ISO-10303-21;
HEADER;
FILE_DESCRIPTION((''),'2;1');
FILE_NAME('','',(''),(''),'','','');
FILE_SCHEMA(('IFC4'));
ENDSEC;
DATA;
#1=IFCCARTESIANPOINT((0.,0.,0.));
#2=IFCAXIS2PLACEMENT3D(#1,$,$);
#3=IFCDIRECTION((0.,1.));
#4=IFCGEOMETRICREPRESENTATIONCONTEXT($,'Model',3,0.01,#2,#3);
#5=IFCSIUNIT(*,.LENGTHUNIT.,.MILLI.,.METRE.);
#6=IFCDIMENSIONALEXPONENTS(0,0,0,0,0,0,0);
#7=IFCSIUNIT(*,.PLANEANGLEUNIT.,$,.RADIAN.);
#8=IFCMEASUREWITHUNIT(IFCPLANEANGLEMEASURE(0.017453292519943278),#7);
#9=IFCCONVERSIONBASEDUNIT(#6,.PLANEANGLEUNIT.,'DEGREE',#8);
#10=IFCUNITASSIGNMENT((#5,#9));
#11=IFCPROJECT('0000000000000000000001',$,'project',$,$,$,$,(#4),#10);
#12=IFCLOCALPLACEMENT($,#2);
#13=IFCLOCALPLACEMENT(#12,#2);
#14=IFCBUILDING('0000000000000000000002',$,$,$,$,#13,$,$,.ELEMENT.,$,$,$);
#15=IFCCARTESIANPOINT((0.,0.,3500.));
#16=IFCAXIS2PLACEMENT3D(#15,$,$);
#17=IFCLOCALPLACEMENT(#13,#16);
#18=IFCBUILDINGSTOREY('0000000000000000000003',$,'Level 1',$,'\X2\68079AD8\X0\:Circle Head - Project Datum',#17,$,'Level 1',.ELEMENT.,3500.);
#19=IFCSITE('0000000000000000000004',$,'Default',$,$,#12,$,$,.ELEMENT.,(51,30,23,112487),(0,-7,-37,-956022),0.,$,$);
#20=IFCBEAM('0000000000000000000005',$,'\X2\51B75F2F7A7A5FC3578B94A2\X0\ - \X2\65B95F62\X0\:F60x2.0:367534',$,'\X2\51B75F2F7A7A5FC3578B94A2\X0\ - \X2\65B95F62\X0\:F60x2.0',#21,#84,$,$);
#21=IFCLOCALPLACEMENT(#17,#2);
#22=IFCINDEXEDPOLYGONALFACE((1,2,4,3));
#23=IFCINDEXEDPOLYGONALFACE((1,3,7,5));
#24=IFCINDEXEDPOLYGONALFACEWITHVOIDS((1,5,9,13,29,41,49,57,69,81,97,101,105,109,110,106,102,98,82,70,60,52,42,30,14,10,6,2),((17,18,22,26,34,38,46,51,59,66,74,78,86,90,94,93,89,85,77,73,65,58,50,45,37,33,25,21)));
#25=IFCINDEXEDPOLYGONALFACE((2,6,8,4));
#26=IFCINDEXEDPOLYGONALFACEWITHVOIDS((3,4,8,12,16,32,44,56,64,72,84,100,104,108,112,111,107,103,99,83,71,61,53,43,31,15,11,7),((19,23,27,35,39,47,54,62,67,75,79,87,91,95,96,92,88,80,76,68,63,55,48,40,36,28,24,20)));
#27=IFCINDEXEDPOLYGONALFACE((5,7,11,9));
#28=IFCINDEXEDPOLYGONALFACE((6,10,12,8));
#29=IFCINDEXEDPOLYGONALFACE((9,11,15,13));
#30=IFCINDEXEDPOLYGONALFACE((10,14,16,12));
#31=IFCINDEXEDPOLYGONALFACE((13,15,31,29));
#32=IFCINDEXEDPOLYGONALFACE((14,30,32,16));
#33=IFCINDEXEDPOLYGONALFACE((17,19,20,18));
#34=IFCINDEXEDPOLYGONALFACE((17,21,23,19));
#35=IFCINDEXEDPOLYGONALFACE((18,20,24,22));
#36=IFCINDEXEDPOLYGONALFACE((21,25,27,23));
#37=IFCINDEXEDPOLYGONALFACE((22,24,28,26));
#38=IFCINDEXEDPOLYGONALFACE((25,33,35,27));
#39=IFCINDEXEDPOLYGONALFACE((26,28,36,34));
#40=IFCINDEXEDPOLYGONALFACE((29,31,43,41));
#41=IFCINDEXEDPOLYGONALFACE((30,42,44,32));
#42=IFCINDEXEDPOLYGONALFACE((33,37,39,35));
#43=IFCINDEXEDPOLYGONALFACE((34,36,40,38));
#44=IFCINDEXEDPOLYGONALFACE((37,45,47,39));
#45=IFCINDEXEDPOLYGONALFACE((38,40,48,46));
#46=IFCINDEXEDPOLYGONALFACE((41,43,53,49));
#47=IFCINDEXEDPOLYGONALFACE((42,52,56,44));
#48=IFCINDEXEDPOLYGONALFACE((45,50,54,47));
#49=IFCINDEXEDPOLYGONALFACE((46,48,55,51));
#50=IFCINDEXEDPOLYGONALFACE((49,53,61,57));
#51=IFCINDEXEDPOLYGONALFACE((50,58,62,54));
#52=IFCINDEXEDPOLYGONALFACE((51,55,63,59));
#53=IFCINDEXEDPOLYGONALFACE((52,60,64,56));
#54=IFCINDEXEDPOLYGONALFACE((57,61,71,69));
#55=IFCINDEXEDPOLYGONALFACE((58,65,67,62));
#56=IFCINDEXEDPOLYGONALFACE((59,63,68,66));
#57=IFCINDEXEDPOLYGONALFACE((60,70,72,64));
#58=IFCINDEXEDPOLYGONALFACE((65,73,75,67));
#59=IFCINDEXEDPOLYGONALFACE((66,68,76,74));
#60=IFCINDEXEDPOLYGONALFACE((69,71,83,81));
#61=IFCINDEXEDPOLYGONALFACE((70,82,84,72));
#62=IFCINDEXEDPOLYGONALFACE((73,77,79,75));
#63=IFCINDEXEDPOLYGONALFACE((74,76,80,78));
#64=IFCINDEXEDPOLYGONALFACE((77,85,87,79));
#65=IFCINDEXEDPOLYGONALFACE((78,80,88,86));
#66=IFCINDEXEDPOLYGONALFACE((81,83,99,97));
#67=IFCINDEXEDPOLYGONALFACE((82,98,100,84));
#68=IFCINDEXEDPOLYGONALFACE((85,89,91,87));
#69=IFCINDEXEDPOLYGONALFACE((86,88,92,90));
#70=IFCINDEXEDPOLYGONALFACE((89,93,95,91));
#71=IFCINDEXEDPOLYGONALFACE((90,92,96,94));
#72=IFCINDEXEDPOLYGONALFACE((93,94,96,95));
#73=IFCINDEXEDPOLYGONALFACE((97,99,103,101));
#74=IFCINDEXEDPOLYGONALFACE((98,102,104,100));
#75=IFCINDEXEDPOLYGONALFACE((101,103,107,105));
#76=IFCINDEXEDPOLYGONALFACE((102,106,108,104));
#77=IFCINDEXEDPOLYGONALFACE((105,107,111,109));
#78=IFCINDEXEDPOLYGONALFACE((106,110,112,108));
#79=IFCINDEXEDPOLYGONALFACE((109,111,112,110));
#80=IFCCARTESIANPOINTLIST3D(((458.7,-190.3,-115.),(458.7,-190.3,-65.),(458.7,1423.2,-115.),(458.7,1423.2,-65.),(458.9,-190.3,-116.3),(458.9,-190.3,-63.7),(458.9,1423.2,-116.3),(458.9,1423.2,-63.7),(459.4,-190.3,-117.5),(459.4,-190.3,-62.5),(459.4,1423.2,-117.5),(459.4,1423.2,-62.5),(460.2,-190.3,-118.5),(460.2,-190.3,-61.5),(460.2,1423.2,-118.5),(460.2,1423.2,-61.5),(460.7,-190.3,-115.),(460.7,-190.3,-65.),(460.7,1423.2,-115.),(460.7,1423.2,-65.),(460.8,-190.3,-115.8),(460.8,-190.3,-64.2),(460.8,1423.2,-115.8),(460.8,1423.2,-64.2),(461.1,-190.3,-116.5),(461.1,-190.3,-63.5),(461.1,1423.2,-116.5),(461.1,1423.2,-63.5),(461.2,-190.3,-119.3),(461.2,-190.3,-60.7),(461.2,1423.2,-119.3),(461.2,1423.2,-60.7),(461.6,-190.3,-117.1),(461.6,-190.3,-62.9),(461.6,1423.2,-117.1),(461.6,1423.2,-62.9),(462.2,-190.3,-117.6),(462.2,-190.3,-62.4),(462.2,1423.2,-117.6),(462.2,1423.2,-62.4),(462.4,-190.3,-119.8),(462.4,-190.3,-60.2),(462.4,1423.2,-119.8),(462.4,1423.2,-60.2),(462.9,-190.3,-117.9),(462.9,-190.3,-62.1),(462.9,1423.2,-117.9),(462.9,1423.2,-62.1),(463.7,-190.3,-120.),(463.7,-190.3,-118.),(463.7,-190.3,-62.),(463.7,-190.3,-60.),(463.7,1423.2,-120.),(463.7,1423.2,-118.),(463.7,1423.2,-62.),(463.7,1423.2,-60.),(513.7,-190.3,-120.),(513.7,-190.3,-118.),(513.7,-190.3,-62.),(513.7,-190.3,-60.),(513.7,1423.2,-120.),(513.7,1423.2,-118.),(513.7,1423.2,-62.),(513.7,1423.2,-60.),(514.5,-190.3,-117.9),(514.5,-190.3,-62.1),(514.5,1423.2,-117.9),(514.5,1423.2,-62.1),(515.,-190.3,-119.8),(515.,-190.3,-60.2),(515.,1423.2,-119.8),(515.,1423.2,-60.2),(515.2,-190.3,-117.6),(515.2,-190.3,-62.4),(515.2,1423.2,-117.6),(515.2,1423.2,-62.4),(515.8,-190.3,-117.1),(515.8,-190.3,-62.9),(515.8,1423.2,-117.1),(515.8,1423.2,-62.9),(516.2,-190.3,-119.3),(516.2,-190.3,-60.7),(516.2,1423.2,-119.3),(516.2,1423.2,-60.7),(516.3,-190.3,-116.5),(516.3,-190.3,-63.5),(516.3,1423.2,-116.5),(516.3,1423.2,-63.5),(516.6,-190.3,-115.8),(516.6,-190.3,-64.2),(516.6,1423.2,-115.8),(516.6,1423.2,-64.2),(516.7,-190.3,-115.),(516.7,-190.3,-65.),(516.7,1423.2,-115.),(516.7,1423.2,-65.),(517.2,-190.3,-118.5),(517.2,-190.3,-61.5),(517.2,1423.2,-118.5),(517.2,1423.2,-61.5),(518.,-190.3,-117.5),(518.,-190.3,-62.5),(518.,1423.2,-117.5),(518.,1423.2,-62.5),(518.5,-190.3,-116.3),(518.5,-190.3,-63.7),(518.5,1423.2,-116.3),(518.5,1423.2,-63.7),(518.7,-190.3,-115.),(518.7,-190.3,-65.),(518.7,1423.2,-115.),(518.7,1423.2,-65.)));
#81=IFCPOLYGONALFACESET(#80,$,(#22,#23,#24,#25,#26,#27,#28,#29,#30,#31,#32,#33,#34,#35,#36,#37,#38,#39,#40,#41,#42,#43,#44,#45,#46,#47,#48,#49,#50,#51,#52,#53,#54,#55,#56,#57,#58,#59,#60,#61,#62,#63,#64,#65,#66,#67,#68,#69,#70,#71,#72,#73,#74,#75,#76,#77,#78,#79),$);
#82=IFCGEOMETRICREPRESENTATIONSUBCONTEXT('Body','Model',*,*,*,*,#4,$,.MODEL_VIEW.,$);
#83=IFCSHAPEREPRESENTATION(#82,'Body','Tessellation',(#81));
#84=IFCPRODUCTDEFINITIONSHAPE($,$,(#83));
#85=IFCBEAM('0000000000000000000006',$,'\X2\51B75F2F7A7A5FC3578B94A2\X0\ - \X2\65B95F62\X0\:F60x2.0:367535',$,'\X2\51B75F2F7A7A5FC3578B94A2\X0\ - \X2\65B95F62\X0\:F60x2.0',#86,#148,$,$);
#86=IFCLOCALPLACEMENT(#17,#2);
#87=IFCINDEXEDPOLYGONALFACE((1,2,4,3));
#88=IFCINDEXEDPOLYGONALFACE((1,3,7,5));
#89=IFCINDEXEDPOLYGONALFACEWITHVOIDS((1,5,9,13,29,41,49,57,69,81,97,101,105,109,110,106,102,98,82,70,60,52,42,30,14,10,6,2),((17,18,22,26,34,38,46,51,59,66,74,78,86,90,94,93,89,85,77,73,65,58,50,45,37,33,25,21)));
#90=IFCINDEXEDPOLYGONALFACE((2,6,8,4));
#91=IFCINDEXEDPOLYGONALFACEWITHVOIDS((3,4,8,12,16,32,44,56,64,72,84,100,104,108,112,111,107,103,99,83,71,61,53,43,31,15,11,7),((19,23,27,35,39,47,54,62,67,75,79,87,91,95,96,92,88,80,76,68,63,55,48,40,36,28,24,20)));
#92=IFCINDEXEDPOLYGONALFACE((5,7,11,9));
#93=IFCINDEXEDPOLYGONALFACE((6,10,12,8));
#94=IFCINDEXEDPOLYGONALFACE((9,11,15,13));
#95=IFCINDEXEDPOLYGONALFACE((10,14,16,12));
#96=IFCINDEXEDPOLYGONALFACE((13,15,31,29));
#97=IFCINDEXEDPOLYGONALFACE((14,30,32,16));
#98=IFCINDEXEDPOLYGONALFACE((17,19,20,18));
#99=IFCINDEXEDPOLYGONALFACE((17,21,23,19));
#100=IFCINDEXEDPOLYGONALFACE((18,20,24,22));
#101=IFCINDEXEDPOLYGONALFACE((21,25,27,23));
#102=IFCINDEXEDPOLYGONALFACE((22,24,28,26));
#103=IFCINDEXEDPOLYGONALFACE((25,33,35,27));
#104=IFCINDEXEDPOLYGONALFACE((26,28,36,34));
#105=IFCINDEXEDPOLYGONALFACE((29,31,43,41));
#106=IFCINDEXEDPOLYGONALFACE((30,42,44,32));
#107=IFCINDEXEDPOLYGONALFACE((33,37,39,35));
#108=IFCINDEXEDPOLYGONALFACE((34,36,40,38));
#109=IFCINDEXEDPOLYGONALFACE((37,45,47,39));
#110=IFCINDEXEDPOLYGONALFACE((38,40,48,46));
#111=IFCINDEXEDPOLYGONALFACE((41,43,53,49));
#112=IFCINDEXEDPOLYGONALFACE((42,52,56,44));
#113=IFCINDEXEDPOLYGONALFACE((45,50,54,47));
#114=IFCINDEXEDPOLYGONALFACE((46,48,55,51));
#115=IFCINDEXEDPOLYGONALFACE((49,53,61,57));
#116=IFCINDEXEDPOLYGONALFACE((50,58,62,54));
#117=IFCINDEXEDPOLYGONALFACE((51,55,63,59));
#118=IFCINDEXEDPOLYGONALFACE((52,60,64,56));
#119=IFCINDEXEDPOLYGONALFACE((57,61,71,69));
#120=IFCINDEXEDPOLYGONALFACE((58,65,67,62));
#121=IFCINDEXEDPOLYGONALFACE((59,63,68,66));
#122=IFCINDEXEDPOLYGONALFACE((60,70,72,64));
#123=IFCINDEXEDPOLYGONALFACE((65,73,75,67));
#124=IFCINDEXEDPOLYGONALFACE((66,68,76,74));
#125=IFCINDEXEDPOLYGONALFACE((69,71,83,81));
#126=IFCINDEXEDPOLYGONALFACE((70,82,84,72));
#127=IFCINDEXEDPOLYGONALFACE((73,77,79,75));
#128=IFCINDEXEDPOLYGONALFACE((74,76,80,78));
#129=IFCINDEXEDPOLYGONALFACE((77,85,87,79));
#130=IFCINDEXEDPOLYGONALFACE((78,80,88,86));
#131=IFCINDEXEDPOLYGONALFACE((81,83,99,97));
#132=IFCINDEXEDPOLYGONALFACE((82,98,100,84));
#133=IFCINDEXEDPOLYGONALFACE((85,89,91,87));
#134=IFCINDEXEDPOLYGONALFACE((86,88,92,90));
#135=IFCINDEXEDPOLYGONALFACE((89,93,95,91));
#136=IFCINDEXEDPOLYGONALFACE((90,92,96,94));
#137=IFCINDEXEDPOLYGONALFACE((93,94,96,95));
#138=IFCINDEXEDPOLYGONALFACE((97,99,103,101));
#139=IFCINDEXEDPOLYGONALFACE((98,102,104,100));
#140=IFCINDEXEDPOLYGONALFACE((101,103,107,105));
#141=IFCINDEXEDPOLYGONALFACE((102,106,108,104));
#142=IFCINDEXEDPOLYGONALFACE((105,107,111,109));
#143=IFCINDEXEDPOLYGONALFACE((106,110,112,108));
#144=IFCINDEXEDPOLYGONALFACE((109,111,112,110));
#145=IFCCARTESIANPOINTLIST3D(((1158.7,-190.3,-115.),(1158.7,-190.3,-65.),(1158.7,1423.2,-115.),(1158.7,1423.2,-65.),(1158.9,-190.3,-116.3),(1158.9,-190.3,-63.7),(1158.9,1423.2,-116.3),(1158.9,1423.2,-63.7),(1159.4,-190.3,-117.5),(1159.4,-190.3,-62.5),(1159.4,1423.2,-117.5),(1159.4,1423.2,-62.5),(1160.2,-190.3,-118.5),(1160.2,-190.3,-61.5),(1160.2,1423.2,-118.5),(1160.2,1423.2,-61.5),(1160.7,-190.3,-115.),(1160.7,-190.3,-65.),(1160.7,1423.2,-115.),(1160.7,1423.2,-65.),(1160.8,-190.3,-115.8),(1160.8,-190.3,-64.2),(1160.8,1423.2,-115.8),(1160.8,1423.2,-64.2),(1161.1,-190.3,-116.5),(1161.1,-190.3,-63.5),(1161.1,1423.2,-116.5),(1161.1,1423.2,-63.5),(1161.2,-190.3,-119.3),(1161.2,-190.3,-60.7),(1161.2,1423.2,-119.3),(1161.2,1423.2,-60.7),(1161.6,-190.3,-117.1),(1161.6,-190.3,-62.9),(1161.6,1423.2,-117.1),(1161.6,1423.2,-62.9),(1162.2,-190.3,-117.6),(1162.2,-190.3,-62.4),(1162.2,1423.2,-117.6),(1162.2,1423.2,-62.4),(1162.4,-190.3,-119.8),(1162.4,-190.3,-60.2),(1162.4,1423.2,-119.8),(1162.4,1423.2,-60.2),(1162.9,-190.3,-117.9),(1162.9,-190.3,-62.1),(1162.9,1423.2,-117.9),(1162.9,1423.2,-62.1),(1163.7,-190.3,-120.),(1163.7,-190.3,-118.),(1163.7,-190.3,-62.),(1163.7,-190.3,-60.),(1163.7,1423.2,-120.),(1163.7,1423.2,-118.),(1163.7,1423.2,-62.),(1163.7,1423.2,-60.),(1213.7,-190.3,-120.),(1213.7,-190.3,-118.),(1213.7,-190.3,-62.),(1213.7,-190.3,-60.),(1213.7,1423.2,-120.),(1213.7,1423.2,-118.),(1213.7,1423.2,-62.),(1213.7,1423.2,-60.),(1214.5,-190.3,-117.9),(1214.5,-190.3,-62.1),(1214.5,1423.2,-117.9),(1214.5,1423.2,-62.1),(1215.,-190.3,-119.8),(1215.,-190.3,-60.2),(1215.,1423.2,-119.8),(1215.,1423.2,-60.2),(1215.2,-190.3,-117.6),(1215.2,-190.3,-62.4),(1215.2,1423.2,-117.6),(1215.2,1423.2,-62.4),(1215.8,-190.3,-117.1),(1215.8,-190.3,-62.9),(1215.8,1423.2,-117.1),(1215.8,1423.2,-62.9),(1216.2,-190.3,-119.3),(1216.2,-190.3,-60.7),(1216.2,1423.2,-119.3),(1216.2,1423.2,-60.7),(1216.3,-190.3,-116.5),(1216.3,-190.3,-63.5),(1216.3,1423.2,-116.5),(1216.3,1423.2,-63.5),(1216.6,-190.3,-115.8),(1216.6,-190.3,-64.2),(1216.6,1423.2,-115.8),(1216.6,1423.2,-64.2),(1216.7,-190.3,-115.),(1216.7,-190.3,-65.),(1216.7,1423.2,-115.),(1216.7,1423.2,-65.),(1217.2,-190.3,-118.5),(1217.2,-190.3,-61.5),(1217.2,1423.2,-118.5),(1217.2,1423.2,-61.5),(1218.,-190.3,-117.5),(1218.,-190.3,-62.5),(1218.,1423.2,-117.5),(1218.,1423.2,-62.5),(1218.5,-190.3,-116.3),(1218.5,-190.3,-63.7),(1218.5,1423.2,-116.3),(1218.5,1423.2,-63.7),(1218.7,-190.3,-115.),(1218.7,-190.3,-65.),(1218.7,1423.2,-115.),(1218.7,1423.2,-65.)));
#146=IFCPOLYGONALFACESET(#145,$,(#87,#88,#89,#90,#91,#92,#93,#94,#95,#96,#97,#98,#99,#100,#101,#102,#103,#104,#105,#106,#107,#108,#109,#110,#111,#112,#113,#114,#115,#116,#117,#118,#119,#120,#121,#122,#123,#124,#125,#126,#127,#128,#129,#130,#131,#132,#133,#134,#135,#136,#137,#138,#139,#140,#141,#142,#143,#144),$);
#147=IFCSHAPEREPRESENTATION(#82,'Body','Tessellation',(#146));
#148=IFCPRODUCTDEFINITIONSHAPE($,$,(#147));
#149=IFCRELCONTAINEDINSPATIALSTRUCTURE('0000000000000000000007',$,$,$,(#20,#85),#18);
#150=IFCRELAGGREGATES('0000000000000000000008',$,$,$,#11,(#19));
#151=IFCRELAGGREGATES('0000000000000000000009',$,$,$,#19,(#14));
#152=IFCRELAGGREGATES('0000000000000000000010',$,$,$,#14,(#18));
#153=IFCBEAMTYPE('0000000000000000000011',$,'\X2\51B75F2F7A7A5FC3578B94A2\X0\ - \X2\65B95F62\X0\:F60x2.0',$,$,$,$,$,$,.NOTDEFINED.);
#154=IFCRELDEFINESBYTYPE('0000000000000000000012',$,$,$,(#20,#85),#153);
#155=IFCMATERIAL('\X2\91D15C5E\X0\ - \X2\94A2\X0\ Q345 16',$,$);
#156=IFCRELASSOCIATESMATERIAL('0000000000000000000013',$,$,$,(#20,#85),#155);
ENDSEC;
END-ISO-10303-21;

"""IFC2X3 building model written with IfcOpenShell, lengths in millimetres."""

from ifc_helpers import new_model, entity, si_unit, converted_unit, direction, frame, frame_2d, origin, place, context, subcontext, project, spatial, polyline, circle_curve, parameter, trimmed, segment, composite_curve, outline, extrude, material, type_object, element, save


model = new_model("IFC2X3")

# Units and contexts
model_context = context("Model", 3, precision=0.01, world=origin(), true_north=direction((0.0, 1.0)))
body_context = subcontext(model_context, "Body", "Model", "MODEL_VIEW")
ifc_project = project(units=[si_unit("LENGTHUNIT", "METRE", prefix="MILLI"), converted_unit("PLANEANGLEUNIT", "DEGREE", entity("IfcPlaneAngleMeasure", 0.017453292519943278), si_unit("PLANEANGLEUNIT", "RADIAN"), dimensions=[0, 0, 0, 0, 0, 0, 0])], contexts=[model_context])

# Site, building, storey
site_placement = place(None, origin())
site = spatial("IfcSite", under=ifc_project, at=site_placement, Name="Default", CompositionType="ELEMENT", RefLatitude=(51, 30, 23, 112487), RefLongitude=(0, -7, -37, -956022), RefElevation=0.0)
building_placement = place(site_placement, origin())
building = spatial("IfcBuilding", under=site, at=building_placement, CompositionType="ELEMENT")
storey_placement = place(building_placement, frame((0.0, 0.0, 3500.0)))
storey = spatial("IfcBuildingStorey", under=building, at=storey_placement, Name="Level 1", ObjectType="标高:Circle Head - Project Datum", LongName="Level 1", CompositionType="ELEMENT", Elevation=3500.0)

# Beams
ifc_material_1 = material(Name="金属 - 钢 Q345 16")
beam_type_1 = type_object("IfcBeamType", Name="冷弯空心型钢 - 方形:F60x2.0", PredefinedType="NOTDEFINED")
beam_1_placement = place(storey_placement, frame((488.7, 1388.1, -60.0), z_axis=(0.0, 0.0, 1.0), x_axis=(0.0, -1.0, 0.0)))
element("IfcBeam", 1, at=beam_1_placement, inside=storey, type_object=beam_type_1, material=ifc_material_1, Name="冷弯空心型钢 - 方形:F60x2.0:367534", ObjectType="冷弯空心型钢 - 方形:F60x2.0", context=body_context, shape_type="SweptSolid", body=[
    extrude(outline(composite_curve([segment(trimmed(circle_curve(frame_2d((-25.0, 25.0), x_axis=(1.0, 0.0)), 5.0), [parameter(90.0)], [parameter(180.0)], True, "PARAMETER"), True, "CONTINUOUS"), segment(polyline([(-30.0, 25.0), (-30.0, -25.0)]), True, "CONTINUOUS"), segment(trimmed(circle_curve(frame_2d((-25.0, -25.0), x_axis=(1.0, 0.0)), 5.0), [parameter(180.0)], [parameter(270.0)], True, "PARAMETER"), True, "CONTINUOUS"), segment(polyline([(-25.0, -30.0), (25.0, -30.0)]), True, "CONTINUOUS"), segment(trimmed(circle_curve(frame_2d((25.0, -25.0), x_axis=(1.0, 0.0)), 5.0), [parameter(270.0)], [parameter(0.0)], True, "PARAMETER"), True, "CONTINUOUS"), segment(polyline([(30.0, -25.0), (30.0, 25.0)]), True, "CONTINUOUS"), segment(trimmed(circle_curve(frame_2d((25.0, 25.0), x_axis=(1.0, 0.0)), 5.0), [parameter(0.0)], [parameter(90.0)], True, "PARAMETER"), True, "CONTINUOUS"), segment(polyline([(25.0, 30.0), (-25.0, 30.0)]), True, "CONTINUOUS")], self_intersect=False), holes=[composite_curve([segment(polyline([(-25.0, 28.0), (25.0, 28.0)]), True, "CONTINUOUS"), segment(trimmed(circle_curve(frame_2d((25.0, 25.0), x_axis=(1.0, 0.0)), 3.0), [parameter(0.0)], [parameter(90.0)], True, "PARAMETER"), False, "CONTINUOUS"), segment(polyline([(28.0, 25.0), (28.0, -25.0)]), True, "CONTINUOUS"), segment(trimmed(circle_curve(frame_2d((25.0, -25.0), x_axis=(1.0, 0.0)), 3.0), [parameter(270.0)], [parameter(360.0)], True, "PARAMETER"), False, "CONTINUOUS"), segment(polyline([(25.0, -28.0), (-25.0, -28.0)]), True, "CONTINUOUS"), segment(trimmed(circle_curve(frame_2d((-25.0, -25.0), x_axis=(1.0, 0.0)), 3.0), [parameter(180.0)], [parameter(270.0)], True, "PARAMETER"), False, "CONTINUOUS"), segment(polyline([(-28.0, -25.0), (-28.0, 25.0)]), True, "CONTINUOUS"), segment(trimmed(circle_curve(frame_2d((-25.0, 25.0), x_axis=(1.0, 0.0)), 3.0), [parameter(90.0)], [parameter(180.0)], True, "PARAMETER"), False, "CONTINUOUS")], self_intersect=False)]), frame((-35.1, 0.0, -30.0), z_axis=(1.0, 0.0, 0.0), x_axis=(0.0, 1.0, 0.0)), (0.0, 0.0, 1.0), 1613.5),
])
beam_2_placement = place(storey_placement, frame((1188.7, 1388.1, -60.0), z_axis=(0.0, 0.0, 1.0), x_axis=(0.0, -1.0, 0.0)))
element("IfcBeam", 2, at=beam_2_placement, inside=storey, type_object=beam_type_1, material=ifc_material_1, Name="冷弯空心型钢 - 方形:F60x2.0:367535", ObjectType="冷弯空心型钢 - 方形:F60x2.0", context=body_context, shape_type="SweptSolid", body=[
    extrude(outline(composite_curve([segment(trimmed(circle_curve(frame_2d((-25.0, 25.0), x_axis=(1.0, 0.0)), 5.0), [parameter(90.0)], [parameter(180.0)], True, "PARAMETER"), True, "CONTINUOUS"), segment(polyline([(-30.0, 25.0), (-30.0, -25.0)]), True, "CONTINUOUS"), segment(trimmed(circle_curve(frame_2d((-25.0, -25.0), x_axis=(1.0, 0.0)), 5.0), [parameter(180.0)], [parameter(270.0)], True, "PARAMETER"), True, "CONTINUOUS"), segment(polyline([(-25.0, -30.0), (25.0, -30.0)]), True, "CONTINUOUS"), segment(trimmed(circle_curve(frame_2d((25.0, -25.0), x_axis=(1.0, 0.0)), 5.0), [parameter(270.0)], [parameter(0.0)], True, "PARAMETER"), True, "CONTINUOUS"), segment(polyline([(30.0, -25.0), (30.0, 25.0)]), True, "CONTINUOUS"), segment(trimmed(circle_curve(frame_2d((25.0, 25.0), x_axis=(1.0, 0.0)), 5.0), [parameter(0.0)], [parameter(90.0)], True, "PARAMETER"), True, "CONTINUOUS"), segment(polyline([(25.0, 30.0), (-25.0, 30.0)]), True, "CONTINUOUS")], self_intersect=False), holes=[composite_curve([segment(polyline([(-25.0, 28.0), (25.0, 28.0)]), True, "CONTINUOUS"), segment(trimmed(circle_curve(frame_2d((25.0, 25.0), x_axis=(1.0, 0.0)), 3.0), [parameter(0.0)], [parameter(90.0)], True, "PARAMETER"), False, "CONTINUOUS"), segment(polyline([(28.0, 25.0), (28.0, -25.0)]), True, "CONTINUOUS"), segment(trimmed(circle_curve(frame_2d((25.0, -25.0), x_axis=(1.0, 0.0)), 3.0), [parameter(270.0)], [parameter(360.0)], True, "PARAMETER"), False, "CONTINUOUS"), segment(polyline([(25.0, -28.0), (-25.0, -28.0)]), True, "CONTINUOUS"), segment(trimmed(circle_curve(frame_2d((-25.0, -25.0), x_axis=(1.0, 0.0)), 3.0), [parameter(180.0)], [parameter(270.0)], True, "PARAMETER"), False, "CONTINUOUS"), segment(polyline([(-28.0, -25.0), (-28.0, 25.0)]), True, "CONTINUOUS"), segment(trimmed(circle_curve(frame_2d((-25.0, 25.0), x_axis=(1.0, 0.0)), 3.0), [parameter(90.0)], [parameter(180.0)], True, "PARAMETER"), False, "CONTINUOUS")], self_intersect=False)]), frame((-35.1, 0.0, -30.0), z_axis=(1.0, 0.0, 0.0), x_axis=(0.0, 1.0, 0.0)), (0.0, 0.0, 1.0), 1613.5),
])

save(model, "model.ifc")
